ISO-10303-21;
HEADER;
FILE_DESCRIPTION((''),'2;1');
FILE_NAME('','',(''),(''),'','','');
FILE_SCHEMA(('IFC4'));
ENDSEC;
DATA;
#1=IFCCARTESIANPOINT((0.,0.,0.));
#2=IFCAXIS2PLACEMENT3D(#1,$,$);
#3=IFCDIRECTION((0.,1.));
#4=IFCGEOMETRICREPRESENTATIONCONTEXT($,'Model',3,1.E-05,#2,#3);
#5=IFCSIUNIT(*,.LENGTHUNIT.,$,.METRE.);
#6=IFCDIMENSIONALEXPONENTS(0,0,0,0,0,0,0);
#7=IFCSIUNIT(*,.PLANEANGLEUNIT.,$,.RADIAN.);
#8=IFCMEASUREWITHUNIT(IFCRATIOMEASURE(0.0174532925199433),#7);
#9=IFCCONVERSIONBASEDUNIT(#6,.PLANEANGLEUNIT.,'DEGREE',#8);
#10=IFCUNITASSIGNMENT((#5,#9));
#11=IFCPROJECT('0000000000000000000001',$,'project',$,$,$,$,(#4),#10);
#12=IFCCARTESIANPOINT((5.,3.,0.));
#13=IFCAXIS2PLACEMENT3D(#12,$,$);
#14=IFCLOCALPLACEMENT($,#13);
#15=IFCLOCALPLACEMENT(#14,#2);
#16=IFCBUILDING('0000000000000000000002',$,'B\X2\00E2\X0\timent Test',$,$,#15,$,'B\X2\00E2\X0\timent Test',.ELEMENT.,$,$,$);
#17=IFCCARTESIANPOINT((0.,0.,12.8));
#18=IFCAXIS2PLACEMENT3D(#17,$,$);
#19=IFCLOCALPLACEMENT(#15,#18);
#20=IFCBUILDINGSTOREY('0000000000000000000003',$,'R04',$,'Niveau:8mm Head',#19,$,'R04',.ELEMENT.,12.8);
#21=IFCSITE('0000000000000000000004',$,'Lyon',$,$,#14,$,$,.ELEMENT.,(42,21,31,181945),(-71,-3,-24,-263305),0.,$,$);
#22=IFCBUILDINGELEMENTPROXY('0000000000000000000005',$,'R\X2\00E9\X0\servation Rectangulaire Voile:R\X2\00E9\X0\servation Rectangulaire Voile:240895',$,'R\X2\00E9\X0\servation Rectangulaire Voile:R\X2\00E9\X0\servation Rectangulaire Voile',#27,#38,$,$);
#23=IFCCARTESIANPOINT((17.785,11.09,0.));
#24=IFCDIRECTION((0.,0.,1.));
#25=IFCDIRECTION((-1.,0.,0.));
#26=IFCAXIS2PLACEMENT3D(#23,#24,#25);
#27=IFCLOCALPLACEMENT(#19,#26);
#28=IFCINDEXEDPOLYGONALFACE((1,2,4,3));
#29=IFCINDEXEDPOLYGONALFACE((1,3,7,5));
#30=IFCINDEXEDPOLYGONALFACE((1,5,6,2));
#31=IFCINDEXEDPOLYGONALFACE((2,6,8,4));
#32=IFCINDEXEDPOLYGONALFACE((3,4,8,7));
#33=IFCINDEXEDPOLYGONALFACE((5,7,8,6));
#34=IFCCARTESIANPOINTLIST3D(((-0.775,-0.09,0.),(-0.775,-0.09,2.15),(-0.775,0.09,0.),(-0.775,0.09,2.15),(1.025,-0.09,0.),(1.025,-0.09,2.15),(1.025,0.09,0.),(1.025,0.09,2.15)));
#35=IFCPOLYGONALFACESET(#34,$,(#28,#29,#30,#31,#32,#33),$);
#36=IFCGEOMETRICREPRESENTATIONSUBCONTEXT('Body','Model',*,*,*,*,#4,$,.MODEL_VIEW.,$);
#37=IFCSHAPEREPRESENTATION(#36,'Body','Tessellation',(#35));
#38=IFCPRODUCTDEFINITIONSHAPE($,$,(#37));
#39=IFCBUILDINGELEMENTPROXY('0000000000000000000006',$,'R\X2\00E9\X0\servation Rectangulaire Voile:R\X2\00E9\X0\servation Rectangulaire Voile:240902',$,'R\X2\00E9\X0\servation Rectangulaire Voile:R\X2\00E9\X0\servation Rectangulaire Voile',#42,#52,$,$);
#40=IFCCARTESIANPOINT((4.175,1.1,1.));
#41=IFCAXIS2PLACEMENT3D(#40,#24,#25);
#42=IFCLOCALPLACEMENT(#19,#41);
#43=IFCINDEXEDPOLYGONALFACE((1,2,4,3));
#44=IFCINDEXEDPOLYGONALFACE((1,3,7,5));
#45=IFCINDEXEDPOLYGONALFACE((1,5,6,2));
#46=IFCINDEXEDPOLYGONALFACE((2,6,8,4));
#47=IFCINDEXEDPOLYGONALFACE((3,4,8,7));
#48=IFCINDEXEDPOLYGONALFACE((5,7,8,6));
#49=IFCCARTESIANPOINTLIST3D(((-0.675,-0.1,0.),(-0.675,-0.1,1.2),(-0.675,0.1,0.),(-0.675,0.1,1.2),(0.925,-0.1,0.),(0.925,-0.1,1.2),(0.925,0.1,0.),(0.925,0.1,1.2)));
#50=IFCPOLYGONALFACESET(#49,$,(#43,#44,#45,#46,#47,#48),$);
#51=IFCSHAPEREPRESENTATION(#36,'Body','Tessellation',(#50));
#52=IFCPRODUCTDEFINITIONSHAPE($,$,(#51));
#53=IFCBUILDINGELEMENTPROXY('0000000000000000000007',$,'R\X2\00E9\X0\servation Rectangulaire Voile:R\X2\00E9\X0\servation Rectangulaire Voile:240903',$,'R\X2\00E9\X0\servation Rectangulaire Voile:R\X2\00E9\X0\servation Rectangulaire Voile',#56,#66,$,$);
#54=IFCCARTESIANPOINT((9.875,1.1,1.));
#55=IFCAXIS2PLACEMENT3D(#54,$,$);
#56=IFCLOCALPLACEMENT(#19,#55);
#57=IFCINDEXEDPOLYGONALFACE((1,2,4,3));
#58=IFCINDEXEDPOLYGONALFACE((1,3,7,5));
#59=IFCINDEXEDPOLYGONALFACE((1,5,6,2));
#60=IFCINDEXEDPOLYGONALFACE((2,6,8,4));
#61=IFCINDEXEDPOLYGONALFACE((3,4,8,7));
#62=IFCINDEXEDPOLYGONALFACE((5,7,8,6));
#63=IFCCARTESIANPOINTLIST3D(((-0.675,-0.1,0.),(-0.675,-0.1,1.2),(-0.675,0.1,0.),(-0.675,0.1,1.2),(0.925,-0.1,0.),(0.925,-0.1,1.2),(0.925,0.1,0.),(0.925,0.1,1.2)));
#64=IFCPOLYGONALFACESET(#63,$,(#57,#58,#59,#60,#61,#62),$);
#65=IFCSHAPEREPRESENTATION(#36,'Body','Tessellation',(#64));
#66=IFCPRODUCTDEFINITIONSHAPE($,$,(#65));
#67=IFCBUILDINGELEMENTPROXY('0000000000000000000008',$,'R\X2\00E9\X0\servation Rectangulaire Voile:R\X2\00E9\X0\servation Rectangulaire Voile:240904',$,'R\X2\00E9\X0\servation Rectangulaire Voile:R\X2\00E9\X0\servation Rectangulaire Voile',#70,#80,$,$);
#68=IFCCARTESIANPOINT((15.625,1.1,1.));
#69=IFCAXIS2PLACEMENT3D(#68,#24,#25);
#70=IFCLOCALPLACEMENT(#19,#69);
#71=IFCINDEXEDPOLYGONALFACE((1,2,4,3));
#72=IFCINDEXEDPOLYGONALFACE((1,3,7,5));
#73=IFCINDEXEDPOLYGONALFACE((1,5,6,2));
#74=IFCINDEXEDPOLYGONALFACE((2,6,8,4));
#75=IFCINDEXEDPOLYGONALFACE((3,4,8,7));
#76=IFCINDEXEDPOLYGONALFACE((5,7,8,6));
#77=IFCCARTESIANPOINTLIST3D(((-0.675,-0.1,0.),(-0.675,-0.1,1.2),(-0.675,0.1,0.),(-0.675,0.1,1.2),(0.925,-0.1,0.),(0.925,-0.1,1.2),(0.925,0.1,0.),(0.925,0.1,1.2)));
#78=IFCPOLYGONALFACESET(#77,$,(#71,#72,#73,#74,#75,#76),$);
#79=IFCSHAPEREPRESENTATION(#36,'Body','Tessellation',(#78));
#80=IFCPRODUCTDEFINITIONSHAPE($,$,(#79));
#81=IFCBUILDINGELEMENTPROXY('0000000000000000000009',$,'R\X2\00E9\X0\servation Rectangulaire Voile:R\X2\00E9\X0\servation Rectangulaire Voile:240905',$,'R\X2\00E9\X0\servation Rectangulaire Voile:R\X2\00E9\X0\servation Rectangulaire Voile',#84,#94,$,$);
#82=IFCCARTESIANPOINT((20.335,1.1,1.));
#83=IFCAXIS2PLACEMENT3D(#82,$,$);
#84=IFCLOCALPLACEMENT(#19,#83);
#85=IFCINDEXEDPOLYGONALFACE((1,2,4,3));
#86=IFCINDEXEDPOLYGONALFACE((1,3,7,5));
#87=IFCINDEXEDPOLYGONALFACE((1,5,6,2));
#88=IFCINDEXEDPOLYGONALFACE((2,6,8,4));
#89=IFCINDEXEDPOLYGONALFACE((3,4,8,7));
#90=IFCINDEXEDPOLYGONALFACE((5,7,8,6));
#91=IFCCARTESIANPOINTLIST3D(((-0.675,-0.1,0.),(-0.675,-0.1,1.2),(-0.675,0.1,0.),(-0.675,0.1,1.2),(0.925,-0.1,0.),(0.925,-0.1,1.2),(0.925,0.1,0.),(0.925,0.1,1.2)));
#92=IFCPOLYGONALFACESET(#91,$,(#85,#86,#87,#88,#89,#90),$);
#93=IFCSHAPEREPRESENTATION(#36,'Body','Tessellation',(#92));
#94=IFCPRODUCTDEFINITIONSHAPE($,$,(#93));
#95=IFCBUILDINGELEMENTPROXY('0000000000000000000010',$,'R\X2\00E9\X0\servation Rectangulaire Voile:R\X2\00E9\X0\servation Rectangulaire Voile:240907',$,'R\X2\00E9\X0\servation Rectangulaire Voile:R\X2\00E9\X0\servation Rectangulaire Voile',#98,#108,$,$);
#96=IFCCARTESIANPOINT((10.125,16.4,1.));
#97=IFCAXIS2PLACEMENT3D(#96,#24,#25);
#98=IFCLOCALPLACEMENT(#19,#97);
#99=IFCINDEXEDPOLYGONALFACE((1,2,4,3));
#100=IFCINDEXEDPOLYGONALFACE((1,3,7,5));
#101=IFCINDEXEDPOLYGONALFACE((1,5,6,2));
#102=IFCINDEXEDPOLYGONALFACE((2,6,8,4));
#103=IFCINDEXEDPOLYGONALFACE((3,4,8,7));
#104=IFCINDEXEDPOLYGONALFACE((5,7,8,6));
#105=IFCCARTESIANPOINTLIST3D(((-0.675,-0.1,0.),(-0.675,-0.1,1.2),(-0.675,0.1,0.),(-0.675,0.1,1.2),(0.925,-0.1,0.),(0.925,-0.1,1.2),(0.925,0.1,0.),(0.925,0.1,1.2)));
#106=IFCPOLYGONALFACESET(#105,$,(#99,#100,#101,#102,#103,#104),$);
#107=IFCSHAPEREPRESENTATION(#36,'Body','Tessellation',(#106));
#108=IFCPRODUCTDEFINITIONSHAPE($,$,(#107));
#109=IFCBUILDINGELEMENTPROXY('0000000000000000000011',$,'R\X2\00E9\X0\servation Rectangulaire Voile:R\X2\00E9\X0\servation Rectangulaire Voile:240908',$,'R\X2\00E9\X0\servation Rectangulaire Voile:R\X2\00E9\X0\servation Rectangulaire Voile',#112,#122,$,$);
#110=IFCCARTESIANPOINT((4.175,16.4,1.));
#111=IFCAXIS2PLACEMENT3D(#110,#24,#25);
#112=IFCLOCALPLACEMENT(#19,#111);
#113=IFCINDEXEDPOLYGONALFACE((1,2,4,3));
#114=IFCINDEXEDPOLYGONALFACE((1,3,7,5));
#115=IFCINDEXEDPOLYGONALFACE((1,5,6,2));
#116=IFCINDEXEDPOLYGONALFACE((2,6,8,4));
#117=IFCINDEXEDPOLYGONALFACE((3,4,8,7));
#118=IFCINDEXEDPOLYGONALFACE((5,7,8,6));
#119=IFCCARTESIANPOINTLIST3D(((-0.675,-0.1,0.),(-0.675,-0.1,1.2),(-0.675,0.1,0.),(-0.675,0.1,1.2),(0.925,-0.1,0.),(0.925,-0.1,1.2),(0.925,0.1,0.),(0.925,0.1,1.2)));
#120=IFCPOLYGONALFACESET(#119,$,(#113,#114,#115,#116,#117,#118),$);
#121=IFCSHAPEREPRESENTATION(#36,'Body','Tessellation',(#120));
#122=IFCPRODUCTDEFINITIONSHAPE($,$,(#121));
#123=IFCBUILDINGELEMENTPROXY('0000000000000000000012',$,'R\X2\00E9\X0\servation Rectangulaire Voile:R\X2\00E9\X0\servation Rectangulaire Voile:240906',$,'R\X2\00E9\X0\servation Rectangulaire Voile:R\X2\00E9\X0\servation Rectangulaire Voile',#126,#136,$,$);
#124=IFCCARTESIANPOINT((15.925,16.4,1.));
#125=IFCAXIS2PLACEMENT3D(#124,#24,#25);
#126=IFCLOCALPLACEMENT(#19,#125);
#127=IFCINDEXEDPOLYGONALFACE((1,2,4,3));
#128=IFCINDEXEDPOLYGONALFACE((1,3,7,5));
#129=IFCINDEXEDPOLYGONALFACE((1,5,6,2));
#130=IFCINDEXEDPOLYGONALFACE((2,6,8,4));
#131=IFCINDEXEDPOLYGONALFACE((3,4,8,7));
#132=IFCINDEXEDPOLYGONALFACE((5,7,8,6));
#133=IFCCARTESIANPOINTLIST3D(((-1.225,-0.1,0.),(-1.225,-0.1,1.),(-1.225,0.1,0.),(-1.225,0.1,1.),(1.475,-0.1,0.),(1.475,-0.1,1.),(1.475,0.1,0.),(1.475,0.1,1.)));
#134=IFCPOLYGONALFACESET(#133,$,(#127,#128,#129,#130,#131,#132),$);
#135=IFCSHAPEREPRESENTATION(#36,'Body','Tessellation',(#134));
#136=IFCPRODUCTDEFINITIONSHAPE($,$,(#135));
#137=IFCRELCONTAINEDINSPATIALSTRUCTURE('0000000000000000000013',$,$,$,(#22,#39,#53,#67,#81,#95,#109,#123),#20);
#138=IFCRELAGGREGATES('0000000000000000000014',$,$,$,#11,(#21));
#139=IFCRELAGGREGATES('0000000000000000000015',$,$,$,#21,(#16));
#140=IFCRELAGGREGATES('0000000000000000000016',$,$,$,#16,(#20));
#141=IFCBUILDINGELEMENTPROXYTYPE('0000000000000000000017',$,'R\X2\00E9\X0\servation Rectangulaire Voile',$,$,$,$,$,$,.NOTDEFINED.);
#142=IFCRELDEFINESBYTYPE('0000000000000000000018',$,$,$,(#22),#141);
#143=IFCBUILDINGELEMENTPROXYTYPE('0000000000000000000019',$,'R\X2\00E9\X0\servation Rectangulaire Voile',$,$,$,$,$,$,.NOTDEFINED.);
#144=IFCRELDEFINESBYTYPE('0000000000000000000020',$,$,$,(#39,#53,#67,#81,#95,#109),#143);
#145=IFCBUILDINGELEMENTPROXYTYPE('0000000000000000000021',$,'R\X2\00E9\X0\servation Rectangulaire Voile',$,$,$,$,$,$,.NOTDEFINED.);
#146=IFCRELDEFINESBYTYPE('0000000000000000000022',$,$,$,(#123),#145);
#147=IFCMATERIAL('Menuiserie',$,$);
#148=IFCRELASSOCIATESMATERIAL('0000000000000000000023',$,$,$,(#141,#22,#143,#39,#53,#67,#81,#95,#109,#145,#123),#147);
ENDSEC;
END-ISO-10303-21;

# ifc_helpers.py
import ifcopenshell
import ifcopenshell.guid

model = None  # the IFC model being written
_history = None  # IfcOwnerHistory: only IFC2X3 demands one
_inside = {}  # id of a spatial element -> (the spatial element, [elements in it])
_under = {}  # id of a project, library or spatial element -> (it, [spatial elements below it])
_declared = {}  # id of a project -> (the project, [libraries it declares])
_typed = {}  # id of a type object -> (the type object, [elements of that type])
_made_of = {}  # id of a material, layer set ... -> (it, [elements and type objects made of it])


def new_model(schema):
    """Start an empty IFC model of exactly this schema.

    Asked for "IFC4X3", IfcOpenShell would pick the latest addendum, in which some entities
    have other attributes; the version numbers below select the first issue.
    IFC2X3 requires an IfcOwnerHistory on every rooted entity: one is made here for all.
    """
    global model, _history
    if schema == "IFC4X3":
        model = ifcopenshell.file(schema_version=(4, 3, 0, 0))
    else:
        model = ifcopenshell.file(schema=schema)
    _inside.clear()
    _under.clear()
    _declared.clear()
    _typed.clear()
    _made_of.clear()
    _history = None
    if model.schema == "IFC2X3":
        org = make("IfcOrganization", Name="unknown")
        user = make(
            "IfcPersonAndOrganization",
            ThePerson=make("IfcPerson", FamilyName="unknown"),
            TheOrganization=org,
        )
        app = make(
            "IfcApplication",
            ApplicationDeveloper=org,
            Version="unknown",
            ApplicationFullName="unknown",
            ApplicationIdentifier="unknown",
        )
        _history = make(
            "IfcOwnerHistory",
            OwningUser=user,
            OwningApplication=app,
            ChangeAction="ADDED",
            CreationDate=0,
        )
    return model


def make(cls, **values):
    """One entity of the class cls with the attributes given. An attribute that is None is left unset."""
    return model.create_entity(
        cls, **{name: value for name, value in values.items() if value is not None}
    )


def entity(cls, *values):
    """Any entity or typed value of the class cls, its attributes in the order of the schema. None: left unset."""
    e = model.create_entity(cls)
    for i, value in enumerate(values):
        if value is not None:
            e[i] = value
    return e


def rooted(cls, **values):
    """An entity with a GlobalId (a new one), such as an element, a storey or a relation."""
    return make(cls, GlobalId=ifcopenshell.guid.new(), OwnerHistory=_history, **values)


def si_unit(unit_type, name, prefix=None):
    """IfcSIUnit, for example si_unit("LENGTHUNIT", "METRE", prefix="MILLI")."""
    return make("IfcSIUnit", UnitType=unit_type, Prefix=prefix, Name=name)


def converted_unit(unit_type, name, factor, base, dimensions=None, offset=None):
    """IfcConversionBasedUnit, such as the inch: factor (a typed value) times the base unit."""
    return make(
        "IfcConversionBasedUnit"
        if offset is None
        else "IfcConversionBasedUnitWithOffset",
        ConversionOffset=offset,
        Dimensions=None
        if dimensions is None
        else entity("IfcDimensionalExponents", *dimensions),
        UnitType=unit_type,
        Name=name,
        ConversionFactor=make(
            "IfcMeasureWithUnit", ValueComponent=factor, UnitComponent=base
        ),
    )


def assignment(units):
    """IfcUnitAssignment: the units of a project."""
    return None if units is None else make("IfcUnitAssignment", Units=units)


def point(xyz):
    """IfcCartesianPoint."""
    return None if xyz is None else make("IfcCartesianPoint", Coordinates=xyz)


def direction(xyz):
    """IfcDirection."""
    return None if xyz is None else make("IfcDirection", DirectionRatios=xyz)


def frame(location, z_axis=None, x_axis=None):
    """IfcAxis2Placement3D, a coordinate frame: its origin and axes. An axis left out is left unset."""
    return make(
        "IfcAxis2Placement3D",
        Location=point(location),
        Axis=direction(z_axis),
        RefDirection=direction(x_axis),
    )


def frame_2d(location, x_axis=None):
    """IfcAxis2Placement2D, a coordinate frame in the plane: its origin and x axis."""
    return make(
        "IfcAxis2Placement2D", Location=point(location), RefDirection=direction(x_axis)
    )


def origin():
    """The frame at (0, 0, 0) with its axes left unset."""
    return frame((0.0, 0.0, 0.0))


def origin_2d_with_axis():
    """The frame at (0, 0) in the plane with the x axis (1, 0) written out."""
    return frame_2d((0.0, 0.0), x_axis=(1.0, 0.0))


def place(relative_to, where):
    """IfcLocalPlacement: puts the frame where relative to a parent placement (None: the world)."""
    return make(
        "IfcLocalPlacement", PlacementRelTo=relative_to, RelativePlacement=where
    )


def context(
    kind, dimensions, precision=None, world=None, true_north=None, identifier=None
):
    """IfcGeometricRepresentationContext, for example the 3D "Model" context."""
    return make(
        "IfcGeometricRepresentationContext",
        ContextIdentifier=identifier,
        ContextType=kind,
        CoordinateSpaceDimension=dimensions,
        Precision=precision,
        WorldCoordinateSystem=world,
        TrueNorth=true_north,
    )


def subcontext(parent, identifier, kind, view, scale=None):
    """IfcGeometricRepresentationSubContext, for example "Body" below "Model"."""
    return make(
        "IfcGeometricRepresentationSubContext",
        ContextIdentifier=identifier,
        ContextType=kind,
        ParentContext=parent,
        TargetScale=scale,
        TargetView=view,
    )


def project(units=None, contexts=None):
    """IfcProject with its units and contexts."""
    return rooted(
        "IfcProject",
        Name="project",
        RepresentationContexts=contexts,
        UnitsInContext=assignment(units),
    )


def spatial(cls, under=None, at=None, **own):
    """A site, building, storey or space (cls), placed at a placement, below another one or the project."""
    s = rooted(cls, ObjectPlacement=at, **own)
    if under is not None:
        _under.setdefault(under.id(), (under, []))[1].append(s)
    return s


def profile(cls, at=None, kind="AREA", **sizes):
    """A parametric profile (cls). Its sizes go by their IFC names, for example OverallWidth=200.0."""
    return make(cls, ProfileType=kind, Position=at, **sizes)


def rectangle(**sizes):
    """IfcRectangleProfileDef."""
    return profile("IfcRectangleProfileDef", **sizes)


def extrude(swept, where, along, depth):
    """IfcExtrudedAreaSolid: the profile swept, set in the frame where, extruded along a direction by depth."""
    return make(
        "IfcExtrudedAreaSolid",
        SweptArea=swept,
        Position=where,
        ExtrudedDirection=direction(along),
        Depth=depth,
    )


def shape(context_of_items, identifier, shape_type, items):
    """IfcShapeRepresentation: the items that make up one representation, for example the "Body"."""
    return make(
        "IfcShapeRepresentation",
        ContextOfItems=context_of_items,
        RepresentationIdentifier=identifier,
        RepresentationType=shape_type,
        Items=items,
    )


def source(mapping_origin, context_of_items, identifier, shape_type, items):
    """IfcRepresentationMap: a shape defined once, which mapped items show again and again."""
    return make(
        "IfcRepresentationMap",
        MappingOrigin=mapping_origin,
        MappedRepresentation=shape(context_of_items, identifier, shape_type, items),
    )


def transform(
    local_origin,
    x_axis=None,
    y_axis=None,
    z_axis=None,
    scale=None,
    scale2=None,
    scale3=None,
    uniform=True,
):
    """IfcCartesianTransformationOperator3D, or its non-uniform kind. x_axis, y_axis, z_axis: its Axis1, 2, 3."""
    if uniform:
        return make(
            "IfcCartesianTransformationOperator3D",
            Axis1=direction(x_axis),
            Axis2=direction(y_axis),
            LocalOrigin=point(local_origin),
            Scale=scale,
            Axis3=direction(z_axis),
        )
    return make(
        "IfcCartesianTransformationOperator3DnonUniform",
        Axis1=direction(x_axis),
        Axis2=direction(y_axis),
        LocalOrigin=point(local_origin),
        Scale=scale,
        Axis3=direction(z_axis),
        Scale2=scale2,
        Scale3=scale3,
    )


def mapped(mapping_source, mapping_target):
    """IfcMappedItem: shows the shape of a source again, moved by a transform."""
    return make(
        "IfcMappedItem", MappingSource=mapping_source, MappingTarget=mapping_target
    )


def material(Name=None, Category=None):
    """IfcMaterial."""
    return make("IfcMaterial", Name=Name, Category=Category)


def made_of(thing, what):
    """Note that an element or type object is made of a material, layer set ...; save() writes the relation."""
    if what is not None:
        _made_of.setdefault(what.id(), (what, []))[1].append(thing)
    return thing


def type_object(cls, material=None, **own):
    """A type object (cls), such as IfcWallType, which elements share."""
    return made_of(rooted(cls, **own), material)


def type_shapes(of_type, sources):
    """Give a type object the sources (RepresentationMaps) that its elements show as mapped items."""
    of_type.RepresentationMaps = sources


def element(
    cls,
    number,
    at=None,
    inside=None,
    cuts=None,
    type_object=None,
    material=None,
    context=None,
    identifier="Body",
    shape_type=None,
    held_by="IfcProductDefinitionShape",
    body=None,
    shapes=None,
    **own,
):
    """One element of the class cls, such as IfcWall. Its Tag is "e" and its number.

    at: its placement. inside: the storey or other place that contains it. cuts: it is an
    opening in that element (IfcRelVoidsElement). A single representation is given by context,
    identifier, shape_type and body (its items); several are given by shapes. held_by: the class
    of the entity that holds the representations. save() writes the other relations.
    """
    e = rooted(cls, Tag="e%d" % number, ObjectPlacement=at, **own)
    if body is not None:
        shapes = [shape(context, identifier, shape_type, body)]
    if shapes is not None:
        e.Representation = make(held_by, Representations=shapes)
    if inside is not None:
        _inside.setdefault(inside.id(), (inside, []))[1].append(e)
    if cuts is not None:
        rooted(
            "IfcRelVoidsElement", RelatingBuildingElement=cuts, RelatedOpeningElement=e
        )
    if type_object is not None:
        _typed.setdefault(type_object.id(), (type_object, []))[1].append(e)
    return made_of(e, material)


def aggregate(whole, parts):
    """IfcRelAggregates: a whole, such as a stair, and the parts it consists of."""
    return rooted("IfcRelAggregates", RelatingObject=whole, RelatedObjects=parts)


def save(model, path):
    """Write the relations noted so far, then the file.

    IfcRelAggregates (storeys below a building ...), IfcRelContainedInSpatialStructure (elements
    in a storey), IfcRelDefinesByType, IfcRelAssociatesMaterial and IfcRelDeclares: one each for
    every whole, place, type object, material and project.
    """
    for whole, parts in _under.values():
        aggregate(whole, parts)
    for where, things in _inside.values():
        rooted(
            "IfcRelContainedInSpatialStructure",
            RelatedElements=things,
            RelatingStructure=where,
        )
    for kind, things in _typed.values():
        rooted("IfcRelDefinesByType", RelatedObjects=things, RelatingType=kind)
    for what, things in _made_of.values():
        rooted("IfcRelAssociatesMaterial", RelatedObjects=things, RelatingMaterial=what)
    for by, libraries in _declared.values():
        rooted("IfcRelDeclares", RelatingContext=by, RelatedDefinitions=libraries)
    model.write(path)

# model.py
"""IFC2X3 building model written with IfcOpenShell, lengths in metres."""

from ifc_helpers import new_model, entity, si_unit, converted_unit, direction, frame, origin, origin_2d_with_axis, place, context, subcontext, project, spatial, rectangle, extrude, source, transform, mapped, material, type_object, type_shapes, element, save


model = new_model("IFC2X3")

# Units and contexts
model_context = context("Model", 3, precision=1e-05, world=origin(), true_north=direction((0.0, 1.0)))
body_context = subcontext(model_context, "Body", "Model", "MODEL_VIEW")
ifc_project = project(units=[si_unit("LENGTHUNIT", "METRE"), converted_unit("PLANEANGLEUNIT", "DEGREE", entity("IfcRatioMeasure", 0.0174532925199433), si_unit("PLANEANGLEUNIT", "RADIAN"), dimensions=[0, 0, 0, 0, 0, 0, 0])], contexts=[model_context])

# Site, building, storey
site_placement = place(None, frame((5.0, 3.0, 0.0)))
site = spatial("IfcSite", under=ifc_project, at=site_placement, Name="Lyon", CompositionType="ELEMENT", RefLatitude=(42, 21, 31, 181945), RefLongitude=(-71, -3, -24, -263305), RefElevation=0.0)
building_placement = place(site_placement, origin())
building = spatial("IfcBuilding", under=site, at=building_placement, Name="Bâtiment Test", LongName="Bâtiment Test", CompositionType="ELEMENT")
storey_placement = place(building_placement, frame((0.0, 0.0, 12.8)))
storey = spatial("IfcBuildingStorey", under=building, at=storey_placement, Name="R04", ObjectType="Niveau:8mm Head", LongName="R04", CompositionType="ELEMENT", Elevation=12.8)

# Building element proxies
ifc_material_1 = material(Name="Menuiserie")
building_element_proxy_type_1 = type_object("IfcBuildingElementProxyType", Name="Réservation Rectangulaire Voile", PredefinedType="NOTDEFINED", material=ifc_material_1)
shared_shape_1 = source(origin(), body_context, "Body", "SweptSolid", [
    extrude(rectangle(XDim=0.18, YDim=1.8, at=origin_2d_with_axis()), frame((0.125, 0.0, 0.0), z_axis=(0.0, 0.0, 1.0), x_axis=(0.0, 1.0, 0.0)), (0.0, 0.0, 1.0), 2.15),
])
type_shapes(building_element_proxy_type_1, [shared_shape_1])
proxy_1_placement = place(storey_placement, frame((17.785, 11.09, 0.0), z_axis=(0.0, 0.0, 1.0), x_axis=(-1.0, 0.0, 0.0)))
element("IfcBuildingElementProxy", 1, at=proxy_1_placement, inside=storey, type_object=building_element_proxy_type_1, material=ifc_material_1, Name="Réservation Rectangulaire Voile:Réservation Rectangulaire Voile:240895", ObjectType="Réservation Rectangulaire Voile:Réservation Rectangulaire Voile", context=body_context, shape_type="MappedRepresentation", body=[
    mapped(shared_shape_1, transform((0.0, 0.0, 0.0), scale=1.0)),
])
building_element_proxy_type_2 = type_object("IfcBuildingElementProxyType", Name="Réservation Rectangulaire Voile", PredefinedType="NOTDEFINED", material=ifc_material_1)
shared_shape_2 = source(origin(), body_context, "Body", "SweptSolid", [
    extrude(rectangle(XDim=0.2, YDim=1.6, at=origin_2d_with_axis()), frame((0.125, 0.0, 0.0), z_axis=(0.0, 0.0, 1.0), x_axis=(0.0, 1.0, 0.0)), (0.0, 0.0, 1.0), 1.2),
])
type_shapes(building_element_proxy_type_2, [shared_shape_2])
proxy_2_placement = place(storey_placement, frame((4.175, 1.1, 1.0), z_axis=(0.0, 0.0, 1.0), x_axis=(-1.0, 0.0, 0.0)))
element("IfcBuildingElementProxy", 2, at=proxy_2_placement, inside=storey, type_object=building_element_proxy_type_2, material=ifc_material_1, Name="Réservation Rectangulaire Voile:Réservation Rectangulaire Voile:240902", ObjectType="Réservation Rectangulaire Voile:Réservation Rectangulaire Voile", context=body_context, shape_type="MappedRepresentation", body=[
    mapped(shared_shape_2, transform((0.0, 0.0, 0.0), scale=1.0)),
])
proxy_3_placement = place(storey_placement, frame((9.875, 1.1, 1.0)))
element("IfcBuildingElementProxy", 3, at=proxy_3_placement, inside=storey, type_object=building_element_proxy_type_2, material=ifc_material_1, Name="Réservation Rectangulaire Voile:Réservation Rectangulaire Voile:240903", ObjectType="Réservation Rectangulaire Voile:Réservation Rectangulaire Voile", context=body_context, shape_type="MappedRepresentation", body=[
    mapped(shared_shape_2, transform((0.0, 0.0, 0.0), scale=1.0)),
])
proxy_4_placement = place(storey_placement, frame((15.625, 1.1, 1.0), z_axis=(0.0, 0.0, 1.0), x_axis=(-1.0, 0.0, 0.0)))
element("IfcBuildingElementProxy", 4, at=proxy_4_placement, inside=storey, type_object=building_element_proxy_type_2, material=ifc_material_1, Name="Réservation Rectangulaire Voile:Réservation Rectangulaire Voile:240904", ObjectType="Réservation Rectangulaire Voile:Réservation Rectangulaire Voile", context=body_context, shape_type="MappedRepresentation", body=[
    mapped(shared_shape_2, transform((0.0, 0.0, 0.0), scale=1.0)),
])
proxy_5_placement = place(storey_placement, frame((20.335, 1.1, 1.0)))
element("IfcBuildingElementProxy", 5, at=proxy_5_placement, inside=storey, type_object=building_element_proxy_type_2, material=ifc_material_1, Name="Réservation Rectangulaire Voile:Réservation Rectangulaire Voile:240905", ObjectType="Réservation Rectangulaire Voile:Réservation Rectangulaire Voile", context=body_context, shape_type="MappedRepresentation", body=[
    mapped(shared_shape_2, transform((0.0, 0.0, 0.0), scale=1.0)),
])
for number, where, z_axis, x_axis, name in (
    (6, (10.125, 16.4, 1.0), (0.0, 0.0, 1.0), (-1.0, 0.0, 0.0), "Réservation Rectangulaire Voile:Réservation Rectangulaire Voile:240907"),
    (7, (4.175, 16.4, 1.0), (0.0, 0.0, 1.0), (-1.0, 0.0, 0.0), "Réservation Rectangulaire Voile:Réservation Rectangulaire Voile:240908"),
):
    element("IfcBuildingElementProxy", number, at=place(storey_placement, frame(where, z_axis=z_axis, x_axis=x_axis)), inside=storey, type_object=building_element_proxy_type_2, material=ifc_material_1, Name=name, ObjectType="Réservation Rectangulaire Voile:Réservation Rectangulaire Voile", context=body_context, shape_type="MappedRepresentation", body=[
        mapped(shared_shape_2, transform((0.0, 0.0, 0.0), scale=1.0)),
    ])
building_element_proxy_type_3 = type_object("IfcBuildingElementProxyType", Name="Réservation Rectangulaire Voile", PredefinedType="NOTDEFINED", material=ifc_material_1)
shared_shape_3 = source(origin(), body_context, "Body", "SweptSolid", [
    extrude(rectangle(XDim=0.2, YDim=2.7, at=origin_2d_with_axis()), frame((0.125, 0.0, 0.0), z_axis=(0.0, 0.0, 1.0), x_axis=(0.0, 1.0, 0.0)), (0.0, 0.0, 1.0), 1.0),
])
type_shapes(building_element_proxy_type_3, [shared_shape_3])
proxy_6_placement = place(storey_placement, frame((15.925, 16.4, 1.0), z_axis=(0.0, 0.0, 1.0), x_axis=(-1.0, 0.0, 0.0)))
element("IfcBuildingElementProxy", 8, at=proxy_6_placement, inside=storey, type_object=building_element_proxy_type_3, material=ifc_material_1, Name="Réservation Rectangulaire Voile:Réservation Rectangulaire Voile:240906", ObjectType="Réservation Rectangulaire Voile:Réservation Rectangulaire Voile", context=body_context, shape_type="MappedRepresentation", body=[
    mapped(shared_shape_3, transform((0.0, 0.0, 0.0), scale=1.0)),
])

save(model, "model.ifc")
